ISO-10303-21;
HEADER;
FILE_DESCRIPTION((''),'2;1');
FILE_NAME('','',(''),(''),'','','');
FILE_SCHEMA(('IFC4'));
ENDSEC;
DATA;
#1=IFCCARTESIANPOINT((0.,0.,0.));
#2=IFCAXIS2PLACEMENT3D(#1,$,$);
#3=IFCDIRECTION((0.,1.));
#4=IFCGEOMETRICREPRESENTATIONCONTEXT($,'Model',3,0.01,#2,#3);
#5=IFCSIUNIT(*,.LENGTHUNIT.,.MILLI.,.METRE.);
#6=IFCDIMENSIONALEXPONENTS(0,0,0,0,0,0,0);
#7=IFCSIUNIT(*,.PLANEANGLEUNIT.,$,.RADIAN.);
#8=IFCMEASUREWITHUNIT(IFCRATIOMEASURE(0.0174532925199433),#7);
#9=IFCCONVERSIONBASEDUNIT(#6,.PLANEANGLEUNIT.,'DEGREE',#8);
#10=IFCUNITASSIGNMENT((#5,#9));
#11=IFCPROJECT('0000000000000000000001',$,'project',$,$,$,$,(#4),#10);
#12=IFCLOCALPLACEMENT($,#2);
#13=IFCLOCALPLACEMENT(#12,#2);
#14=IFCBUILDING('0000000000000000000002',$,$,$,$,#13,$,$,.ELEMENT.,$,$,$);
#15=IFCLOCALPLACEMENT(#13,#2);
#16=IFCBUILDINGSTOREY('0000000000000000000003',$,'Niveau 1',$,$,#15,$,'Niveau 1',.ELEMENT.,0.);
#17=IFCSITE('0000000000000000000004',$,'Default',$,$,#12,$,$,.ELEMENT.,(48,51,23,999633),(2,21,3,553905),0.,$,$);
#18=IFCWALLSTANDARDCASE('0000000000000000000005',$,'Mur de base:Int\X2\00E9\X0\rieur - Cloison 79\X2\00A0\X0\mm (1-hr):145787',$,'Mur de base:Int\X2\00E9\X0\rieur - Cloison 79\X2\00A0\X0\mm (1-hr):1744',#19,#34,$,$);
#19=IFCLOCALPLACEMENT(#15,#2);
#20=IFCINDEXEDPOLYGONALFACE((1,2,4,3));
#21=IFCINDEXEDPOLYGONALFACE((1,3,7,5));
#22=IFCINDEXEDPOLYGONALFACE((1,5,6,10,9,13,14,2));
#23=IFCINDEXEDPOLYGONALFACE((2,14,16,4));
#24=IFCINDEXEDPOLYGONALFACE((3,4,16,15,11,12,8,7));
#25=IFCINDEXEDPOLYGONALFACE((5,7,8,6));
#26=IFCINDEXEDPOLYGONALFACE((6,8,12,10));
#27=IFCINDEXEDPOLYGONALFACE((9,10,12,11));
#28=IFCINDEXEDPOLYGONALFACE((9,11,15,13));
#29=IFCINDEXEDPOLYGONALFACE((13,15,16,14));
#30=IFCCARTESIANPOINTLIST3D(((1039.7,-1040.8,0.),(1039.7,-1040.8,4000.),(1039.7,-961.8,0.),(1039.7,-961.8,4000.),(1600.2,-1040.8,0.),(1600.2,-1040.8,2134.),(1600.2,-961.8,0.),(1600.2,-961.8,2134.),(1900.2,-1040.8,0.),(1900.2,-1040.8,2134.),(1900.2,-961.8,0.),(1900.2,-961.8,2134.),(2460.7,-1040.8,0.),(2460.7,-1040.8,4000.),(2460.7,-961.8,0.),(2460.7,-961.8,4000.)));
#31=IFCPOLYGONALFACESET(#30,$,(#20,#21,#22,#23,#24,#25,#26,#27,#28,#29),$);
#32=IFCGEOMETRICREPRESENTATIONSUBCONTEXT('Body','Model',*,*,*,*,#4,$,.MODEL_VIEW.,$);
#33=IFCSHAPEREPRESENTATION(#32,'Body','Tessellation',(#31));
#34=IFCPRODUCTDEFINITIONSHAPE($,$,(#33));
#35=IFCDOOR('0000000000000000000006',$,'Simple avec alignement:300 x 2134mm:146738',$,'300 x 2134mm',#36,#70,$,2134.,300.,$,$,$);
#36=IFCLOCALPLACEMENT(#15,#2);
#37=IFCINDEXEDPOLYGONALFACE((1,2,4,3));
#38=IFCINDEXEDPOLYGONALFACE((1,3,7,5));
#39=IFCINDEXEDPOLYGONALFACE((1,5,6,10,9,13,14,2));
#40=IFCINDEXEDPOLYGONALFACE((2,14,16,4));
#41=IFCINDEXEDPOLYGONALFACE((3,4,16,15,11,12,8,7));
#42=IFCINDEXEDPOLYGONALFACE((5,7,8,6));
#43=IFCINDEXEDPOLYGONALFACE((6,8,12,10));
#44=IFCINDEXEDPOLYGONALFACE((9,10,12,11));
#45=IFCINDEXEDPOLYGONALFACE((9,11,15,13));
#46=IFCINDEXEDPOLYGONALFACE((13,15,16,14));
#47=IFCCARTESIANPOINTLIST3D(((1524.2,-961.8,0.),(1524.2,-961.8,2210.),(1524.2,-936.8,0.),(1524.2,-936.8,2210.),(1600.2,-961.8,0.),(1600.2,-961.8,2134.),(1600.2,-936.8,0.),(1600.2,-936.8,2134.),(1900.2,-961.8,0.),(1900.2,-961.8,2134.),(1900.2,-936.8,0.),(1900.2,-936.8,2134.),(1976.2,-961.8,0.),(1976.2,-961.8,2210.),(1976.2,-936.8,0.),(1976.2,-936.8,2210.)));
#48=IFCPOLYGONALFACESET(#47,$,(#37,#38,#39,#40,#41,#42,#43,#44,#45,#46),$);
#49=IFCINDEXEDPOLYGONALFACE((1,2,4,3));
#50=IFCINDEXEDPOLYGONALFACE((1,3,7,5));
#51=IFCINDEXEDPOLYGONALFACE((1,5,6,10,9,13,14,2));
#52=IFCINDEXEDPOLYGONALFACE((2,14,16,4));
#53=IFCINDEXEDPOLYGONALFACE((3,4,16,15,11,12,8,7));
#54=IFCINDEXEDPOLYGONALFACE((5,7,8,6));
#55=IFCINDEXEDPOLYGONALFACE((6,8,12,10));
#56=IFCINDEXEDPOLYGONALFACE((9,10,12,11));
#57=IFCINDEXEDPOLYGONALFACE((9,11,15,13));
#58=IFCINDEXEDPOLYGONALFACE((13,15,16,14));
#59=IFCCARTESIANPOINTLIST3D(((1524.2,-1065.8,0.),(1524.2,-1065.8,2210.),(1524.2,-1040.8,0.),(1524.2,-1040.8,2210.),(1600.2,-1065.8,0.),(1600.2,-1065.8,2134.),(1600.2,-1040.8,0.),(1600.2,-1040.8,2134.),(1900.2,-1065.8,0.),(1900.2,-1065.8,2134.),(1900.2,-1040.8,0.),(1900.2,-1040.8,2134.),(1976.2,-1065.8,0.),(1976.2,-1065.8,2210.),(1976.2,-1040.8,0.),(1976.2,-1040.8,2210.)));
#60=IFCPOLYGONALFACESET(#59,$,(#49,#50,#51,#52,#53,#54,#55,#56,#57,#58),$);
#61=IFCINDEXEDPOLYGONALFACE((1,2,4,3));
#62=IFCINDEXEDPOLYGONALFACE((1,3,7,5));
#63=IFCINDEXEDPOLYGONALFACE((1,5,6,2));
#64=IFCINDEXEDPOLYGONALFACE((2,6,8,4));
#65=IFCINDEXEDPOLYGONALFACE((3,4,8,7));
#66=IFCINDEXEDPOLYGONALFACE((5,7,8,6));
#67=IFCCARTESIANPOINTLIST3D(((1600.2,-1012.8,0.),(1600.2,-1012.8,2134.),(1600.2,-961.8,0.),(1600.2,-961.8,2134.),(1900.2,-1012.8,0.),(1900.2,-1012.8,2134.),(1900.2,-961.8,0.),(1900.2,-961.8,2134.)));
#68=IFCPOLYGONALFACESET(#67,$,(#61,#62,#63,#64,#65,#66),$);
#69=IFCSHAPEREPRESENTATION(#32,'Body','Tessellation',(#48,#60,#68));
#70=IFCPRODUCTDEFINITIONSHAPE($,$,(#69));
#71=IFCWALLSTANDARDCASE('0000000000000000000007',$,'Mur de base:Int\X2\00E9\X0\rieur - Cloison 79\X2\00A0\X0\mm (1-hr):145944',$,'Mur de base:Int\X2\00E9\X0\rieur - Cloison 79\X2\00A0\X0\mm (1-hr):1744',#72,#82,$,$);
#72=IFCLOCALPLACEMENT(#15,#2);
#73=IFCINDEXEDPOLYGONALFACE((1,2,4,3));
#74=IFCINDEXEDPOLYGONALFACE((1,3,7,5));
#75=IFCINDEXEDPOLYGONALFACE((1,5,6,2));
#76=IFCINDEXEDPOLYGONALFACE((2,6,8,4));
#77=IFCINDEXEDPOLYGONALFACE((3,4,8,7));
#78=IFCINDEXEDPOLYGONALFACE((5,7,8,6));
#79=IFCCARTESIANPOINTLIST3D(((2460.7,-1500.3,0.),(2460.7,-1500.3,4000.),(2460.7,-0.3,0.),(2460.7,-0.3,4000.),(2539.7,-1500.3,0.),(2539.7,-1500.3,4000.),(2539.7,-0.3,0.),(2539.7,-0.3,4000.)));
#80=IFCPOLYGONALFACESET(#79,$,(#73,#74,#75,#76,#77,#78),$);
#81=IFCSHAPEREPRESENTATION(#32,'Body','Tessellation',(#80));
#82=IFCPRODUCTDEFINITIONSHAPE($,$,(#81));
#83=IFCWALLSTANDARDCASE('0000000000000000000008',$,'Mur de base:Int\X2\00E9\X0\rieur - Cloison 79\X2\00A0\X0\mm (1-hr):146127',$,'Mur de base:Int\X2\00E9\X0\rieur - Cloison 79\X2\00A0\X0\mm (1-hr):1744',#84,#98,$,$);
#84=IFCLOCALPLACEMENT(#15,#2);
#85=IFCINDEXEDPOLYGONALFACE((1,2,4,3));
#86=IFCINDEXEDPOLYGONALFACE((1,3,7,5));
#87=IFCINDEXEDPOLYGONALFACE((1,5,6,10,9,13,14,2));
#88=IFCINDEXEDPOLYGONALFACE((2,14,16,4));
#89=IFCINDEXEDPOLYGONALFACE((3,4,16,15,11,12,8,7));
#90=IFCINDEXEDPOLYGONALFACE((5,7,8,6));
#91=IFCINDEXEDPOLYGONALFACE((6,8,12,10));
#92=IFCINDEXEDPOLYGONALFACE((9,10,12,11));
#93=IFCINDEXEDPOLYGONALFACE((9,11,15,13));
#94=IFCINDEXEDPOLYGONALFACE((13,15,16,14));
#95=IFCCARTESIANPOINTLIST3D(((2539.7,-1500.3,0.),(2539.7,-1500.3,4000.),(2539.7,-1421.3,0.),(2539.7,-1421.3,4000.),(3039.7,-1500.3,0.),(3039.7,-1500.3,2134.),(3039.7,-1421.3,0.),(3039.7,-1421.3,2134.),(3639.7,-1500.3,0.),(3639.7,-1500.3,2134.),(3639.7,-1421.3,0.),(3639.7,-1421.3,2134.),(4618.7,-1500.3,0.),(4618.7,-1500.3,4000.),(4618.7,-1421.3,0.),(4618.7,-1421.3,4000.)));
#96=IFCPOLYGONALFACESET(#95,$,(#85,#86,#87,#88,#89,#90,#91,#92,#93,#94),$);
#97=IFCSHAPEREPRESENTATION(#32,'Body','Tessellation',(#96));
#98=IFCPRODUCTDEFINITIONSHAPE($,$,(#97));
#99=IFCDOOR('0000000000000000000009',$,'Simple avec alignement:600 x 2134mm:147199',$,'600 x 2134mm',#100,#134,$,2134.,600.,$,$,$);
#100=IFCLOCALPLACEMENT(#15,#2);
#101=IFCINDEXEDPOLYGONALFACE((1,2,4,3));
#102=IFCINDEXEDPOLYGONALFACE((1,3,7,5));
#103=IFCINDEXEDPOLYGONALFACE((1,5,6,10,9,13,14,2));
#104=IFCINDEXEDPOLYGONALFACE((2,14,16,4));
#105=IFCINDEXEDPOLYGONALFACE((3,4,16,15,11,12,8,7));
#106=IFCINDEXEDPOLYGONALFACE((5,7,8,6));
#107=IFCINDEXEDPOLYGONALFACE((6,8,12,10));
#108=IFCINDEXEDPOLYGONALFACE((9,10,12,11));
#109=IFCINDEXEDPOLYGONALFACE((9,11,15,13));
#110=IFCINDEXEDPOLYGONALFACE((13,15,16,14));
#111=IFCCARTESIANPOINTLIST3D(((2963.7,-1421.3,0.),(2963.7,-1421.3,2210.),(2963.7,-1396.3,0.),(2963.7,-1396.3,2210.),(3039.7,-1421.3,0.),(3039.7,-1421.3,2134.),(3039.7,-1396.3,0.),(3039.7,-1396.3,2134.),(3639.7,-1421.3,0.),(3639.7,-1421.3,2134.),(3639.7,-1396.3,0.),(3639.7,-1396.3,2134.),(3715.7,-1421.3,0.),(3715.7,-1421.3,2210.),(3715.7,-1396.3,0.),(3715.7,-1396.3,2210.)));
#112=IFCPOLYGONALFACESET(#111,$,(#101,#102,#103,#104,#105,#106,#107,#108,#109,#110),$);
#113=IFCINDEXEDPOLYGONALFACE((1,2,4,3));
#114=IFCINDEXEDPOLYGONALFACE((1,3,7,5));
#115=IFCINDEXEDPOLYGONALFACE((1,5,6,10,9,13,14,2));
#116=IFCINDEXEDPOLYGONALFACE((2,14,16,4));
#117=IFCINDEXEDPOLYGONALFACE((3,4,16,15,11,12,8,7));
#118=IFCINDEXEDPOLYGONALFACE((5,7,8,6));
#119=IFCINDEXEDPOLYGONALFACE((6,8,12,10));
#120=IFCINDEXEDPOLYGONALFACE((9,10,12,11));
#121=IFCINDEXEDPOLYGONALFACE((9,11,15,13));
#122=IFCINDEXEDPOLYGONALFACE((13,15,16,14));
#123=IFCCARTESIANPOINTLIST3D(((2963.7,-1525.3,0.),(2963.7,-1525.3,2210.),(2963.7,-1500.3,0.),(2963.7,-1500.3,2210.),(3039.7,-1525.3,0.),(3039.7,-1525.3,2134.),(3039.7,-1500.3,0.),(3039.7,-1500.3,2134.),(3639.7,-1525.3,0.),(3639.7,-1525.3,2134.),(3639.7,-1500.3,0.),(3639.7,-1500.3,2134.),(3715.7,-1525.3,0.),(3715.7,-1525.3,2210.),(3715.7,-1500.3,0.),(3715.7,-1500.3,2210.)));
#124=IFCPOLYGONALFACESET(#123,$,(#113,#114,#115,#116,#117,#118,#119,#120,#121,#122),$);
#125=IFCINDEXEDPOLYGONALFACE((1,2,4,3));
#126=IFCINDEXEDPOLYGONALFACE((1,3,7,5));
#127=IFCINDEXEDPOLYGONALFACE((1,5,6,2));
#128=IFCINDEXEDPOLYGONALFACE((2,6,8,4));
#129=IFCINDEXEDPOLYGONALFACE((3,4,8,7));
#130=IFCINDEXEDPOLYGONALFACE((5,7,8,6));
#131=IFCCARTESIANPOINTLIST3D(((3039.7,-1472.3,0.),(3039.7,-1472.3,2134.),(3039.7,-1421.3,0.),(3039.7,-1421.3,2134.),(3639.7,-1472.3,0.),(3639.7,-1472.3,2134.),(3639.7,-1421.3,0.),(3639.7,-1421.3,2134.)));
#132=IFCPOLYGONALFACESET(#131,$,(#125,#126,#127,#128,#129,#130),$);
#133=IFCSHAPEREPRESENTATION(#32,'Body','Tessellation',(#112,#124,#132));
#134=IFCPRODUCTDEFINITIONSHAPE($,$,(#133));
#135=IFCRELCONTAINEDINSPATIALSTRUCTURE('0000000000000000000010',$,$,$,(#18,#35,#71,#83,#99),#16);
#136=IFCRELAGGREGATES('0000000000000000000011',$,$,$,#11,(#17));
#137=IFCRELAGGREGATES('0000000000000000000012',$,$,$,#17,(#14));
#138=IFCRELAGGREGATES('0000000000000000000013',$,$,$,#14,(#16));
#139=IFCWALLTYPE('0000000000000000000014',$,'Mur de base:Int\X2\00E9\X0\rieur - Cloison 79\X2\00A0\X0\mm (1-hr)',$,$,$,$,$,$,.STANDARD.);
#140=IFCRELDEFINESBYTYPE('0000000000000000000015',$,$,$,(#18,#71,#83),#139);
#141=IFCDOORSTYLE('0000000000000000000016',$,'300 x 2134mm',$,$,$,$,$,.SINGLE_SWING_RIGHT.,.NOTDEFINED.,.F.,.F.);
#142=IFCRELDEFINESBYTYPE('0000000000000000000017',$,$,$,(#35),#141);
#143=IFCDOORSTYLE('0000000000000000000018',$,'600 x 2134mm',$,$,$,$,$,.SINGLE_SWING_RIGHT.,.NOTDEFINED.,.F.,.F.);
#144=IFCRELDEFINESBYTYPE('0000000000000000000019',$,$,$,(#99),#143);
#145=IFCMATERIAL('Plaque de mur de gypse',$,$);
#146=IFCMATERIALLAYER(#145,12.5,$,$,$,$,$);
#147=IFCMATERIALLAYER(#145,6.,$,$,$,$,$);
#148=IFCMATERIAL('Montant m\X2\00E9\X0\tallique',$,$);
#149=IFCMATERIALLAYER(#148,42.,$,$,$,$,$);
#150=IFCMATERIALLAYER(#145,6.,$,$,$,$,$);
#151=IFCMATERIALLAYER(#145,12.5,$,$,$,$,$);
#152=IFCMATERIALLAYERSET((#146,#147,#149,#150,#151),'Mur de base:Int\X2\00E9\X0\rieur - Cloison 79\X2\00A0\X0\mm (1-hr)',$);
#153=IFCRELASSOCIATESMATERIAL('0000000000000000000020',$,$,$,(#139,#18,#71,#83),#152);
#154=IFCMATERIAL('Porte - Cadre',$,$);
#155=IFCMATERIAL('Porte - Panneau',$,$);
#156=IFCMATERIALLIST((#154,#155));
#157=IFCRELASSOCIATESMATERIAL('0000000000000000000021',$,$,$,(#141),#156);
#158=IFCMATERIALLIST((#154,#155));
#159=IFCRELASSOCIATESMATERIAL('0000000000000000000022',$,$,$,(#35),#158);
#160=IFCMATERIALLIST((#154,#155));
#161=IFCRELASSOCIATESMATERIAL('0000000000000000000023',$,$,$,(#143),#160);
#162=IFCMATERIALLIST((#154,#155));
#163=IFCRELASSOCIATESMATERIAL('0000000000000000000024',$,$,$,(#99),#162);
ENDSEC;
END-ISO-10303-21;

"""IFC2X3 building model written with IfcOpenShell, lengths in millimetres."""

from ifc_helpers import new_model, entity, si_unit, converted_unit, direction, frame, frame_2d, origin, origin_2d_with_axis, place, context, subcontext, project, spatial, polyline, rectangle, outline, extrude, source, transform, mapped, material, material_list, layer, layer_set, layer_usage, type_object, type_shapes, element, fill, save


model = new_model("IFC2X3")

# Units and contexts
model_context = context("Model", 3, precision=0.01, world=origin(), true_north=direction((0.0, 1.0)))
body_context = subcontext(model_context, "Body", "Model", "MODEL_VIEW")
ifc_project = project(units=[si_unit("LENGTHUNIT", "METRE", prefix="MILLI"), converted_unit("PLANEANGLEUNIT", "DEGREE", entity("IfcRatioMeasure", 0.0174532925199433), si_unit("PLANEANGLEUNIT", "RADIAN"), dimensions=[0, 0, 0, 0, 0, 0, 0])], contexts=[model_context])

# Site, building, storey
site_placement = place(None, origin())
site = spatial("IfcSite", under=ifc_project, at=site_placement, Name="Default", CompositionType="ELEMENT", RefLatitude=(48, 51, 23, 999633), RefLongitude=(2, 21, 3, 553905), RefElevation=0.0)
building_placement = place(site_placement, origin())
building = spatial("IfcBuilding", under=site, at=building_placement, CompositionType="ELEMENT")
storey_placement = place(building_placement, origin())
storey = spatial("IfcBuildingStorey", under=building, at=storey_placement, Name="Niveau 1", LongName="Niveau 1", CompositionType="ELEMENT", Elevation=0.0)

# Wall, opening, door
ifc_material_1 = material(Name="Plaque de mur de gypse")
ifc_layer_1 = layer(ifc_material_1, 12.5)
ifc_layer_2 = layer(ifc_material_1, 6.0)
ifc_material_2 = material(Name="Montant métallique")
ifc_layer_3 = layer(ifc_material_2, 42.0)
ifc_layer_4 = layer(ifc_material_1, 6.0)
ifc_layer_5 = layer(ifc_material_1, 12.5)
ifc_layer_set_1 = layer_set([ifc_layer_1, ifc_layer_2, ifc_layer_3, ifc_layer_4, ifc_layer_5], Name="Mur de base:Intérieur - Cloison 79 mm (1-hr)")
wall_type_1 = type_object("IfcWallType", Name="Mur de base:Intérieur - Cloison 79 mm (1-hr)", PredefinedType="STANDARD", material=ifc_layer_set_1)
ifc_material_3 = material(Name="Porte - Cadre")
ifc_material_4 = material(Name="Porte - Panneau")
ifc_material_list_1 = material_list([ifc_material_3, ifc_material_4])
door_style_1 = type_object("IfcDoorStyle", Name="300 x 2134mm", ConstructionType="NOTDEFINED", OperationType="SINGLE_SWING_RIGHT", ParameterTakesPrecedence=False, Sizeable=False, material=ifc_material_list_1)
shared_shape_1 = source(origin(), body_context, "Body", "SweptSolid", [
    extrude(outline(polyline([(-226.0, -1124.0), (226.0, -1124.0), (226.0, 1086.0), (150.0, 1086.0), (150.0, -1048.0), (-150.0, -1048.0), (-150.0, 1086.0), (-226.0, 1086.0), (-226.0, -1124.0)])), frame((150.0, 79.0, 1086.0), z_axis=(0.0, 1.0, 0.0), x_axis=(1.0, 0.0, 0.0)), (0.0, 0.0, 1.0), 25.0),
    extrude(outline(polyline([(-1124.0, -226.0), (1086.0, -226.0), (1086.0, -150.0), (-1048.0, -150.0), (-1048.0, 150.0), (1086.0, 150.0), (1086.0, 226.0), (-1124.0, 226.0), (-1124.0, -226.0)])), frame((150.0, -25.0, 1086.0), z_axis=(0.0, 1.0, 0.0), x_axis=(0.0, 0.0, -1.0)), (0.0, 0.0, 1.0), 25.0),
    extrude(rectangle(XDim=51.0, YDim=300.0, at=origin_2d_with_axis()), frame((150.0, 53.5, 0.0), z_axis=(0.0, 0.0, 1.0), x_axis=(0.0, 1.0, 0.0)), (0.0, 0.0, 1.0), 2134.0),
])
type_shapes(door_style_1, [shared_shape_1])
ifc_layer_usage_1 = layer_usage(ifc_layer_set_1, "AXIS2", "NEGATIVE", 39.5)
wall_1_placement = place(storey_placement, frame((1039.7, -1001.3, 0.0)))
wall_1 = element("IfcWallStandardCase", 1, at=wall_1_placement, inside=storey, type_object=wall_type_1, material=ifc_layer_usage_1, Name="Mur de base:Intérieur - Cloison 79 mm (1-hr):145787", ObjectType="Mur de base:Intérieur - Cloison 79 mm (1-hr):1744", context=body_context, shape_type="SweptSolid", body=[
    extrude(rectangle(XDim=1421.0, YDim=79.0, at=frame_2d((710.5, 0.0), x_axis=(-1.0, 0.0))), origin(), (0.0, 0.0, 1.0), 4000.0),
])
opening_1_placement = place(wall_1_placement, frame((560.5, -39.5, 0.0)))
opening_1 = element("IfcOpeningElement", 2, at=opening_1_placement, cuts=wall_1, ObjectType="Opening", context=body_context, shape_type="SweptSolid", body=[
    extrude(rectangle(XDim=300.0, YDim=2134.0, at=frame_2d((1067.0, 150.0), x_axis=(0.0, 1.0))), frame((0.0, 0.0, 0.0), z_axis=(0.0, 1.0, 0.0), x_axis=(0.0, 0.0, 1.0)), (0.0, 0.0, 1.0), 79.0),
])
ifc_material_list_2 = material_list([ifc_material_3, ifc_material_4])
door_1_placement = place(opening_1_placement, origin())
door_1 = element("IfcDoor", 3, at=door_1_placement, inside=storey, type_object=door_style_1, material=ifc_material_list_2, Name="Simple avec alignement:300 x 2134mm:146738", ObjectType="300 x 2134mm", OverallHeight=2134.0, OverallWidth=300.0, context=body_context, shape_type="MappedRepresentation", body=[
    mapped(shared_shape_1, transform((0.0, 0.0, 0.0), scale=1.0)),
])
fill(opening_1, door_1)

# Wall
ifc_layer_usage_2 = layer_usage(ifc_layer_set_1, "AXIS2", "NEGATIVE", 39.5)
wall_2_placement = place(storey_placement, frame((2500.2, -1500.3, 0.0), z_axis=(0.0, 0.0, 1.0), x_axis=(0.0, 1.0, 0.0)))
element("IfcWallStandardCase", 4, at=wall_2_placement, inside=storey, type_object=wall_type_1, material=ifc_layer_usage_2, Name="Mur de base:Intérieur - Cloison 79 mm (1-hr):145944", ObjectType="Mur de base:Intérieur - Cloison 79 mm (1-hr):1744", context=body_context, shape_type="SweptSolid", body=[
    extrude(rectangle(XDim=1500.0, YDim=79.0, at=frame_2d((750.0, 0.0), x_axis=(-1.0, 0.0))), origin(), (0.0, 0.0, 1.0), 4000.0),
])

# Wall, opening, door
ifc_layer_usage_3 = layer_usage(ifc_layer_set_1, "AXIS2", "NEGATIVE", 39.5)
wall_3_placement = place(storey_placement, frame((2539.7, -1460.8, 0.0)))
wall_3 = element("IfcWallStandardCase", 5, at=wall_3_placement, inside=storey, type_object=wall_type_1, material=ifc_layer_usage_3, Name="Mur de base:Intérieur - Cloison 79 mm (1-hr):146127", ObjectType="Mur de base:Intérieur - Cloison 79 mm (1-hr):1744", context=body_context, shape_type="SweptSolid", body=[
    extrude(rectangle(XDim=2079.0, YDim=79.0, at=frame_2d((1039.5, 0.0), x_axis=(-1.0, 0.0))), origin(), (0.0, 0.0, 1.0), 4000.0),
])
opening_2_placement = place(wall_3_placement, frame((500.0, -39.5, 0.0)))
opening_2 = element("IfcOpeningElement", 6, at=opening_2_placement, cuts=wall_3, ObjectType="Opening", context=body_context, shape_type="SweptSolid", body=[
    extrude(rectangle(XDim=600.0, YDim=2134.0, at=frame_2d((1067.0, 300.0), x_axis=(0.0, 1.0))), frame((0.0, 0.0, 0.0), z_axis=(0.0, 1.0, 0.0), x_axis=(0.0, 0.0, 1.0)), (0.0, 0.0, 1.0), 79.0),
])
ifc_material_list_3 = material_list([ifc_material_3, ifc_material_4])
ifc_material_list_4 = material_list([ifc_material_3, ifc_material_4])
door_style_2 = type_object("IfcDoorStyle", Name="600 x 2134mm", ConstructionType="NOTDEFINED", OperationType="SINGLE_SWING_RIGHT", ParameterTakesPrecedence=False, Sizeable=False, material=ifc_material_list_4)
shared_shape_2 = source(origin(), body_context, "Body", "SweptSolid", [
    extrude(outline(polyline([(-376.0, -1124.0), (376.0, -1124.0), (376.0, 1086.0), (300.0, 1086.0), (300.0, -1048.0), (-300.0, -1048.0), (-300.0, 1086.0), (-376.0, 1086.0), (-376.0, -1124.0)])), frame((300.0, 79.0, 1086.0), z_axis=(0.0, 1.0, 0.0), x_axis=(1.0, 0.0, 0.0)), (0.0, 0.0, 1.0), 25.0),
    extrude(outline(polyline([(-1124.0, -376.0), (1086.0, -376.0), (1086.0, -300.0), (-1048.0, -300.0), (-1048.0, 300.0), (1086.0, 300.0), (1086.0, 376.0), (-1124.0, 376.0), (-1124.0, -376.0)])), frame((300.0, -25.0, 1086.0), z_axis=(0.0, 1.0, 0.0), x_axis=(0.0, 0.0, -1.0)), (0.0, 0.0, 1.0), 25.0),
    extrude(rectangle(XDim=51.0, YDim=600.0, at=origin_2d_with_axis()), frame((300.0, 53.5, 0.0), z_axis=(0.0, 0.0, 1.0), x_axis=(0.0, 1.0, 0.0)), (0.0, 0.0, 1.0), 2134.0),
])
type_shapes(door_style_2, [shared_shape_2])
door_2_placement = place(opening_2_placement, origin())
door_2 = element("IfcDoor", 7, at=door_2_placement, inside=storey, type_object=door_style_2, material=ifc_material_list_3, Name="Simple avec alignement:600 x 2134mm:147199", ObjectType="600 x 2134mm", OverallHeight=2134.0, OverallWidth=600.0, context=body_context, shape_type="MappedRepresentation", body=[
    mapped(shared_shape_2, transform((0.0, 0.0, 0.0), scale=1.0)),
])
fill(opening_2, door_2)

save(model, "model.ifc")
